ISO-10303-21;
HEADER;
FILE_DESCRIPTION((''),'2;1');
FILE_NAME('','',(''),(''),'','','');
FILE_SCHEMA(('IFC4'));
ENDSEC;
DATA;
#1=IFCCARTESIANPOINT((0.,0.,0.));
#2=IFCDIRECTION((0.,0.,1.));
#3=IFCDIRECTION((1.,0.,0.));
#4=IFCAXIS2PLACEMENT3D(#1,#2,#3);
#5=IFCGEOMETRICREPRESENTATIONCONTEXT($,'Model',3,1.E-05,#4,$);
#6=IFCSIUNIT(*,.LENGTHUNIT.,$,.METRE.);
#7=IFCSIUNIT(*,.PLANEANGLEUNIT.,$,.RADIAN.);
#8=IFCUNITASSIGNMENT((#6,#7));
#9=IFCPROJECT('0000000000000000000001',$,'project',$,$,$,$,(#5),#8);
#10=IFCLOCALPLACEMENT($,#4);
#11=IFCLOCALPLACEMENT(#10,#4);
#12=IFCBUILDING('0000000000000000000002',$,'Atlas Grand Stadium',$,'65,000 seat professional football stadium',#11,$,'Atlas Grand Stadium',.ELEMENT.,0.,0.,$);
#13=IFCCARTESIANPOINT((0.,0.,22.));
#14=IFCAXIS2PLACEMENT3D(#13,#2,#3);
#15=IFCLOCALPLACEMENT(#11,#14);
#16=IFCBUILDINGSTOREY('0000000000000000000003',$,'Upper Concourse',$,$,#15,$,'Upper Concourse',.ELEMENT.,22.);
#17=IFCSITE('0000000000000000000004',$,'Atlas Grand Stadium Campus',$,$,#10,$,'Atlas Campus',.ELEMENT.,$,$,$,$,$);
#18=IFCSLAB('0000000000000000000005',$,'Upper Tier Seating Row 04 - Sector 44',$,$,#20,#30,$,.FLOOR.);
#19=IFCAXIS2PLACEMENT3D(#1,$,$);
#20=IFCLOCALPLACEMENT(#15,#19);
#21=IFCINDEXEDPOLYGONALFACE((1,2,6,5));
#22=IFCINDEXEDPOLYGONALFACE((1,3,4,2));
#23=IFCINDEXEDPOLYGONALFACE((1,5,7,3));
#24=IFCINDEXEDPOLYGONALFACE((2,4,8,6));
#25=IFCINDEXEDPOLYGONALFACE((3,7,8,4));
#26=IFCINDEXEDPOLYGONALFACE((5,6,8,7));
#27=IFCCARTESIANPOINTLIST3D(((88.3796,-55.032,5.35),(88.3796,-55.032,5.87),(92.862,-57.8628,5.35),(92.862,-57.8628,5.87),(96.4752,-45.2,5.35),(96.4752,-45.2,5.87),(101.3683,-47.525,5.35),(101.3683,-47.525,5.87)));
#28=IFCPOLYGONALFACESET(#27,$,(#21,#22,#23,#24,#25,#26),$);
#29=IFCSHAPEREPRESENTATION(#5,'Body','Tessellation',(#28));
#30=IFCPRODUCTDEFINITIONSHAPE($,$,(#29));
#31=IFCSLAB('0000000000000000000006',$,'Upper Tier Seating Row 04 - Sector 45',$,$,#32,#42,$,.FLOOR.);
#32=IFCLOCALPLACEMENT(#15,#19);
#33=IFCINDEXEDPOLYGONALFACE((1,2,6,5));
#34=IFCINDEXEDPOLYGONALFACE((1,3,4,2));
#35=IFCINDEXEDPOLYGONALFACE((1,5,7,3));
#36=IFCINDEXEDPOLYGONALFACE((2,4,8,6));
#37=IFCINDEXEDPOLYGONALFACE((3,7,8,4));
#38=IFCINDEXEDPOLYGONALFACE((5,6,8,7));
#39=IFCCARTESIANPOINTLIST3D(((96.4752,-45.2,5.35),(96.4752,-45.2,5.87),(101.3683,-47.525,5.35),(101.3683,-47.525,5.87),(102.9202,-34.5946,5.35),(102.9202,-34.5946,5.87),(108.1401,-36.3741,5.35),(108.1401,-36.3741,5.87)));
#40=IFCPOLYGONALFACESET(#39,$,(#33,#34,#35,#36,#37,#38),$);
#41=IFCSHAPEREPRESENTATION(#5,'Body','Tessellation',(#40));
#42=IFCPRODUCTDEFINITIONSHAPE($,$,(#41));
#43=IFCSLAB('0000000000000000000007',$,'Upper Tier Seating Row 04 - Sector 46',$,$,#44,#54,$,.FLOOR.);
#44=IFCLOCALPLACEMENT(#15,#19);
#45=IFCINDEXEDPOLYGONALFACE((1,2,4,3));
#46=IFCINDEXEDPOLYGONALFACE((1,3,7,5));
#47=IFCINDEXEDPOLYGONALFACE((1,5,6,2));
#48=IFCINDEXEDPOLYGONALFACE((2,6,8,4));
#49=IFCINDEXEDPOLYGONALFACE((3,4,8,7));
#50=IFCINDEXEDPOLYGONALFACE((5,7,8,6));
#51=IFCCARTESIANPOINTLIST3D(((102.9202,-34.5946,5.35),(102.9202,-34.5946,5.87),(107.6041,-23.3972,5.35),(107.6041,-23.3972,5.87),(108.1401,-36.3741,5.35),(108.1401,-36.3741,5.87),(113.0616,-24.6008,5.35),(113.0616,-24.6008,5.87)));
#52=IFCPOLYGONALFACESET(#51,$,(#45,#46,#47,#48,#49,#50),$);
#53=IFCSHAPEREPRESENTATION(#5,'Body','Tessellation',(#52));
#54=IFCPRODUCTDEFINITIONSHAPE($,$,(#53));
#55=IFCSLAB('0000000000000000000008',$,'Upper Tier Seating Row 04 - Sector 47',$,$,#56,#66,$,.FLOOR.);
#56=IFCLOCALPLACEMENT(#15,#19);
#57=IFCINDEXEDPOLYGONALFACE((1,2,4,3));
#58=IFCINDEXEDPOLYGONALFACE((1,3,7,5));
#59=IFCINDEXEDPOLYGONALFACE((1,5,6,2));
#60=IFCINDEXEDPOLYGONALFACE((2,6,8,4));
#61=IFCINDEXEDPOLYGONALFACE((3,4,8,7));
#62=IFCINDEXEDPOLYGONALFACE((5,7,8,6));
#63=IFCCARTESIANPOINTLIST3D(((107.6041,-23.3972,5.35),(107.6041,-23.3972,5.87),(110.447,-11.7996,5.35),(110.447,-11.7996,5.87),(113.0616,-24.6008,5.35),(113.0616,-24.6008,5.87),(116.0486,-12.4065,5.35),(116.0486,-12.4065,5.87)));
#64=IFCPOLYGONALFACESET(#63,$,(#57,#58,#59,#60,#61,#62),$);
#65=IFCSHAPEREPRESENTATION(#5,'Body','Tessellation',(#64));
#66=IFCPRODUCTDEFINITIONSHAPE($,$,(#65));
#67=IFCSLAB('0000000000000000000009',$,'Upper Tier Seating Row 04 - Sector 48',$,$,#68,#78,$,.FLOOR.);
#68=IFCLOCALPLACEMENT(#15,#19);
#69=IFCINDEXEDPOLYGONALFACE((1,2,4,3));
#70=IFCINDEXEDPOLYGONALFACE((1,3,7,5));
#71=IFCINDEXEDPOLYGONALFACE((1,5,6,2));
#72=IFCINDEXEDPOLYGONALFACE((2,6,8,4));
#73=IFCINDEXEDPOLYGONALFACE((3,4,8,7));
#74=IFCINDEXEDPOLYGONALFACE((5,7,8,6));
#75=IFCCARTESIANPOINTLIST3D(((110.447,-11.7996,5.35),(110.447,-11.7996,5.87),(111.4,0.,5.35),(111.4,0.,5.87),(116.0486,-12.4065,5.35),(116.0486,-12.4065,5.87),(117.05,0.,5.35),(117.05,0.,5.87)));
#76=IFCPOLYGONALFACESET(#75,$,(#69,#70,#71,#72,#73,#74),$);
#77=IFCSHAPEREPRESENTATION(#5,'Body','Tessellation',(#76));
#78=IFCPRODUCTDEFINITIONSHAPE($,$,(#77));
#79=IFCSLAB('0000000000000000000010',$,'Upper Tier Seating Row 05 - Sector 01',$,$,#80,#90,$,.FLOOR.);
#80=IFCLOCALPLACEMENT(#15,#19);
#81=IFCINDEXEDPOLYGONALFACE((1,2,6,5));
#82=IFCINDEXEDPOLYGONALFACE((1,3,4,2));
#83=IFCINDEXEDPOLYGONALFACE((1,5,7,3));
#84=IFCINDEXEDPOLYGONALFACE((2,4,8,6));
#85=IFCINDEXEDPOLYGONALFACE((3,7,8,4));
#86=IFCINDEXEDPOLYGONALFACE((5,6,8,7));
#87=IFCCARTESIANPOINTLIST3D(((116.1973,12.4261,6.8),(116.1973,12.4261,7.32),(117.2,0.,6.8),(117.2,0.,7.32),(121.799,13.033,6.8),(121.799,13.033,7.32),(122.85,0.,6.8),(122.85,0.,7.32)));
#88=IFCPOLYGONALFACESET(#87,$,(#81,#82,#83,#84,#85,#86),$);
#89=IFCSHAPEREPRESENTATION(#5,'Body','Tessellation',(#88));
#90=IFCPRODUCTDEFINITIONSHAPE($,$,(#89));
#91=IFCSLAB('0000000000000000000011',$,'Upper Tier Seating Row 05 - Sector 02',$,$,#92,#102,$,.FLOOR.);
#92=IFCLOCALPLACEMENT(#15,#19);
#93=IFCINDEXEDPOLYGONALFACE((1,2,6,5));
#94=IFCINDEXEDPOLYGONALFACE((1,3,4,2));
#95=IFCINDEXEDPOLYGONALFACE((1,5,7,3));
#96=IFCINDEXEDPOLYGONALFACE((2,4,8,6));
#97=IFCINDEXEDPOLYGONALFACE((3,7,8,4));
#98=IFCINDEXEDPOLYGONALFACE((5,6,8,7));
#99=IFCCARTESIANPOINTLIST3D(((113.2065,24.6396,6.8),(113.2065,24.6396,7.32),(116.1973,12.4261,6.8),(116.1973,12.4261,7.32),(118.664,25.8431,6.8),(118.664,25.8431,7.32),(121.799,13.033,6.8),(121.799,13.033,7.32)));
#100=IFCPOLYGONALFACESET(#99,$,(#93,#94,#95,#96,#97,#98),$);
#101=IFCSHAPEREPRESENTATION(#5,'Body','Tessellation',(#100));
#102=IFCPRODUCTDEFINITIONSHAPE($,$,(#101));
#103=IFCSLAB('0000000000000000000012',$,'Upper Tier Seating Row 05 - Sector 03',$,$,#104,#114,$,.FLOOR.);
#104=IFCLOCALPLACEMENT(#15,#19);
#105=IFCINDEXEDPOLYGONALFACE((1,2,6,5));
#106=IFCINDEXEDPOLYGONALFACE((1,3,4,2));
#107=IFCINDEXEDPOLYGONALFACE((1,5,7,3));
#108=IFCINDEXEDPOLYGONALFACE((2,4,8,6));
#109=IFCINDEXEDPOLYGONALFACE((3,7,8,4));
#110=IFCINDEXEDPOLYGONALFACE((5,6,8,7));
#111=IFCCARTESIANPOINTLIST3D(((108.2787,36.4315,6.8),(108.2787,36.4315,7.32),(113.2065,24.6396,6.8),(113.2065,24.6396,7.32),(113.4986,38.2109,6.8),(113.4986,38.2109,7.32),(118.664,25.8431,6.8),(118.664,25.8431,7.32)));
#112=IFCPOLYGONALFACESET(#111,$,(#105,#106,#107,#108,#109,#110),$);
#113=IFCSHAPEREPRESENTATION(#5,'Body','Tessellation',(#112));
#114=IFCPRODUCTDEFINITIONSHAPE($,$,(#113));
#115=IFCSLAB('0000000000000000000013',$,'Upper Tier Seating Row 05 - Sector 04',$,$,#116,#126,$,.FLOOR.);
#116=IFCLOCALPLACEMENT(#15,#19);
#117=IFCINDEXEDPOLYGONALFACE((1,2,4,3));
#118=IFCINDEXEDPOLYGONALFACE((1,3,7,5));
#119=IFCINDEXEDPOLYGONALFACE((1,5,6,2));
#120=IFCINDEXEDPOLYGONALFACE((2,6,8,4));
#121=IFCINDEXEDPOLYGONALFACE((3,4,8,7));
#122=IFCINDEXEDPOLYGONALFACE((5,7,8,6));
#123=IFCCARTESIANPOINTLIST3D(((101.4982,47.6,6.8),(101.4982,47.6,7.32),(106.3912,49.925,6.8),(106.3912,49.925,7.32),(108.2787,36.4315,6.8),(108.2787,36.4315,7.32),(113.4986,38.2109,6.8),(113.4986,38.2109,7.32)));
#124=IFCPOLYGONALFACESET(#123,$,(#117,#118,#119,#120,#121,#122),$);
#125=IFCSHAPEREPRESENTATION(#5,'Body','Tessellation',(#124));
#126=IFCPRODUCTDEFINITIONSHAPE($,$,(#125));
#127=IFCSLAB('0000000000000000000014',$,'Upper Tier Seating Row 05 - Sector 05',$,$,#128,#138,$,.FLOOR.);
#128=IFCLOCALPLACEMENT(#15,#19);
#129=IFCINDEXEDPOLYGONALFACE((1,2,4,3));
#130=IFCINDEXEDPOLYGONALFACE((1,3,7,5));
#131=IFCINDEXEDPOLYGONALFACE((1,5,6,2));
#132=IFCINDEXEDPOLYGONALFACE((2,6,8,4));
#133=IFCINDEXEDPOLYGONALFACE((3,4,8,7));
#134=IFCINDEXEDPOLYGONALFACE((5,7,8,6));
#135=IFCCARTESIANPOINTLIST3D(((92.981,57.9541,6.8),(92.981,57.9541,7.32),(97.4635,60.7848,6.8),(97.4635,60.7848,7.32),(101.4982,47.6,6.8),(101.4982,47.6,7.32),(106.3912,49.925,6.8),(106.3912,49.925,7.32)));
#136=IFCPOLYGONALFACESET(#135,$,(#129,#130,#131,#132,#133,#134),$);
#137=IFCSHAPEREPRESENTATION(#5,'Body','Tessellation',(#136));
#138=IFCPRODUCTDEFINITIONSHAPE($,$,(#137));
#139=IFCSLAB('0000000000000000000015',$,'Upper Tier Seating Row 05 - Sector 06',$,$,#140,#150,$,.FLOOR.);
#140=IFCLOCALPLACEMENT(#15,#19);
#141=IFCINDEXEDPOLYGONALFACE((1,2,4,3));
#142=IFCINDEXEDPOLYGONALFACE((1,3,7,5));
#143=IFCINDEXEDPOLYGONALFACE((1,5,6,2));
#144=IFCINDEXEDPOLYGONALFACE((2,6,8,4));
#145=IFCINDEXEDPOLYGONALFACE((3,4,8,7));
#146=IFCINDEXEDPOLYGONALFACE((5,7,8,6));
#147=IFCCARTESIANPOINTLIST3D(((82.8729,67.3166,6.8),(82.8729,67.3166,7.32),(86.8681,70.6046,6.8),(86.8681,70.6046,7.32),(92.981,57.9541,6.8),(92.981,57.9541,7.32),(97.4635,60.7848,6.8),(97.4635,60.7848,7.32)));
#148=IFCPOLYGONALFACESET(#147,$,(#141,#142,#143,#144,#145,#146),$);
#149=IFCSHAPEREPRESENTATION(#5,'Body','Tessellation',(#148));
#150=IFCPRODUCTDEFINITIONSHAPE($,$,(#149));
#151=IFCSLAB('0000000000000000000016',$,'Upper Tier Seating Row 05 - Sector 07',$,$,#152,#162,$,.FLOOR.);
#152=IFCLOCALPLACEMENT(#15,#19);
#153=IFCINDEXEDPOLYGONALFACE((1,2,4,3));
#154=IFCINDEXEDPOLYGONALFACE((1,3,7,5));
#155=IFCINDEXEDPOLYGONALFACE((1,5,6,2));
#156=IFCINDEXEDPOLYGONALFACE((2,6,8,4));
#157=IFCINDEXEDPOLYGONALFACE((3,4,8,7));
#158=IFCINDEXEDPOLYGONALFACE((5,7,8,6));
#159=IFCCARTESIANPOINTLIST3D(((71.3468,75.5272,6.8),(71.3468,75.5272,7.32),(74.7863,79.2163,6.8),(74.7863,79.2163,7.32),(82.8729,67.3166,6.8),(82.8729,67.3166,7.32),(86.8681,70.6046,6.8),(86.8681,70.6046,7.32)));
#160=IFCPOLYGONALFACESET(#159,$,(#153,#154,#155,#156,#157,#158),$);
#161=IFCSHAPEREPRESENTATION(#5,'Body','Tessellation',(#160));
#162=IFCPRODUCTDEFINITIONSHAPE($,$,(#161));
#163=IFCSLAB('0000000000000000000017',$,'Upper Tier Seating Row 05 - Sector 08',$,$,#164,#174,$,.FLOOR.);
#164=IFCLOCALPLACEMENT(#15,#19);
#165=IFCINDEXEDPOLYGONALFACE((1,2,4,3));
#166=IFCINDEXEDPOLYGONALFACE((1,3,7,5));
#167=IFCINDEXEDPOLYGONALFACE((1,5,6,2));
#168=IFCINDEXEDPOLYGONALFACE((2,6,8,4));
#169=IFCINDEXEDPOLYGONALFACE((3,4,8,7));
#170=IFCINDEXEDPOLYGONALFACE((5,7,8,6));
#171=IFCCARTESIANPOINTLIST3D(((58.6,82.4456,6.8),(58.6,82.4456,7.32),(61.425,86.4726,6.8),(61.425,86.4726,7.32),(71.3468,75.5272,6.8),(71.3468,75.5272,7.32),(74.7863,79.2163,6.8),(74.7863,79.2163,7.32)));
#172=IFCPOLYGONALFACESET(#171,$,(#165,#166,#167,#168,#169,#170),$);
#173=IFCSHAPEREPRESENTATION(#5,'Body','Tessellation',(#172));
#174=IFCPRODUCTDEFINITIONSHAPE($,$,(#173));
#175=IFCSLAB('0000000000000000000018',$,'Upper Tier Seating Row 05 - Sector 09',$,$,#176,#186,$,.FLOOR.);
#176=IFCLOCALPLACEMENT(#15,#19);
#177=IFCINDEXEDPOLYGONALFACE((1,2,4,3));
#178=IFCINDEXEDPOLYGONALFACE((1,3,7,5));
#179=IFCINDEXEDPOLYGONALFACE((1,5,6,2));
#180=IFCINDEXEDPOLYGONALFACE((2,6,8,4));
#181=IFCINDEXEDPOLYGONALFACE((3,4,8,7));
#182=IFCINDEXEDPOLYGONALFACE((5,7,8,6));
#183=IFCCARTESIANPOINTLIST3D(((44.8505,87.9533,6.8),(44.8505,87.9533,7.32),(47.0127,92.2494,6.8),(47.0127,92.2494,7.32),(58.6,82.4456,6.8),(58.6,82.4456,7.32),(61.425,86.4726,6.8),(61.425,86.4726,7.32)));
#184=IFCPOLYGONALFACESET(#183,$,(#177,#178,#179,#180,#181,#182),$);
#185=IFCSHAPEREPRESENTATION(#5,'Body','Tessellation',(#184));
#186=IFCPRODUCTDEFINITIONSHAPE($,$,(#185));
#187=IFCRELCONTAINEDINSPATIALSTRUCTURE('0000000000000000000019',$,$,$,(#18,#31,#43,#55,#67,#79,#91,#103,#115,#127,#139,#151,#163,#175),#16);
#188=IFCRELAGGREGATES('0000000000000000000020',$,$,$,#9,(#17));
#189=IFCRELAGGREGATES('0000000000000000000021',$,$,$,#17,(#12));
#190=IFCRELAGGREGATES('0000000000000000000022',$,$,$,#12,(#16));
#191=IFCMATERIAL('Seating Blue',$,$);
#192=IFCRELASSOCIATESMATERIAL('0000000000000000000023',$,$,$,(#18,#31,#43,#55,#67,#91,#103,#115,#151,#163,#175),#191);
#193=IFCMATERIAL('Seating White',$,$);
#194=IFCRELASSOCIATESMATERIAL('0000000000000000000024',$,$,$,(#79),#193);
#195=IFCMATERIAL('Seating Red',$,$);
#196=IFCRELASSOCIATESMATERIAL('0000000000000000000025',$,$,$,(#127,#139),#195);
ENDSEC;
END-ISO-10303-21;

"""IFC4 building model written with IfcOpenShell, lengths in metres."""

from ifc_helpers import new_model, si_unit, frame, origin_with_axes, place, context, project, spatial, polyline, outline, extrude, material, element, save


model = new_model("IFC4")

# Units and contexts
model_context = context("Model", 3, precision=1e-05, world=origin_with_axes())
ifc_project = project(units=[si_unit("LENGTHUNIT", "METRE"), si_unit("PLANEANGLEUNIT", "RADIAN")], contexts=[model_context])

# Site, building, storey
site_placement = place(None, origin_with_axes())
site = spatial("IfcSite", under=ifc_project, at=site_placement, Name="Atlas Grand Stadium Campus", LongName="Atlas Campus", CompositionType="ELEMENT")
building_placement = place(site_placement, origin_with_axes())
building = spatial("IfcBuilding", under=site, at=building_placement, Name="Atlas Grand Stadium", ObjectType="65,000 seat professional football stadium", LongName="Atlas Grand Stadium", CompositionType="ELEMENT", ElevationOfRefHeight=0.0, ElevationOfTerrain=0.0)
storey_placement = place(building_placement, frame((0.0, 0.0, 22.0), z_axis=(0.0, 0.0, 1.0), x_axis=(1.0, 0.0, 0.0)))
storey = spatial("IfcBuildingStorey", under=building, at=storey_placement, Name="Upper Concourse", LongName="Upper Concourse", CompositionType="ELEMENT", Elevation=22.0)

# Slabs
ifc_material_1 = material(Name="Seating Blue")
slab_1_placement = place(storey_placement, frame((0.0, 0.0, 5.35), z_axis=(0.0, 0.0, 1.0), x_axis=(1.0, 0.0, 0.0)))
element("IfcSlab", 1, at=slab_1_placement, inside=storey, material=ifc_material_1, Name="Upper Tier Seating Row 04 - Sector 44", PredefinedType="FLOOR", context=model_context, shape_type="SweptSolid", body=[
    extrude(outline(polyline([(92.862, -57.8628), (101.3683, -47.525), (96.4752, -45.2), (88.3796, -55.032), (92.862, -57.8628)])), origin_with_axes(), (0.0, 0.0, 1.0), 0.52),
])
slab_2_placement = place(storey_placement, frame((0.0, 0.0, 5.35), z_axis=(0.0, 0.0, 1.0), x_axis=(1.0, 0.0, 0.0)))
element("IfcSlab", 2, at=slab_2_placement, inside=storey, material=ifc_material_1, Name="Upper Tier Seating Row 04 - Sector 45", PredefinedType="FLOOR", context=model_context, shape_type="SweptSolid", body=[
    extrude(outline(polyline([(101.3683, -47.525), (108.1401, -36.3741), (102.9202, -34.5946), (96.4752, -45.2), (101.3683, -47.525)])), origin_with_axes(), (0.0, 0.0, 1.0), 0.52),
])
slab_3_placement = place(storey_placement, frame((0.0, 0.0, 5.35), z_axis=(0.0, 0.0, 1.0), x_axis=(1.0, 0.0, 0.0)))
element("IfcSlab", 3, at=slab_3_placement, inside=storey, material=ifc_material_1, Name="Upper Tier Seating Row 04 - Sector 46", PredefinedType="FLOOR", context=model_context, shape_type="SweptSolid", body=[
    extrude(outline(polyline([(108.1401, -36.3741), (113.0616, -24.6008), (107.6041, -23.3972), (102.9202, -34.5946), (108.1401, -36.3741)])), origin_with_axes(), (0.0, 0.0, 1.0), 0.52),
])
slab_4_placement = place(storey_placement, frame((0.0, 0.0, 5.35), z_axis=(0.0, 0.0, 1.0), x_axis=(1.0, 0.0, 0.0)))
element("IfcSlab", 4, at=slab_4_placement, inside=storey, material=ifc_material_1, Name="Upper Tier Seating Row 04 - Sector 47", PredefinedType="FLOOR", context=model_context, shape_type="SweptSolid", body=[
    extrude(outline(polyline([(113.0616, -24.6008), (116.0486, -12.4065), (110.447, -11.7996), (107.6041, -23.3972), (113.0616, -24.6008)])), origin_with_axes(), (0.0, 0.0, 1.0), 0.52),
])
slab_5_placement = place(storey_placement, frame((0.0, 0.0, 5.35), z_axis=(0.0, 0.0, 1.0), x_axis=(1.0, 0.0, 0.0)))
element("IfcSlab", 5, at=slab_5_placement, inside=storey, material=ifc_material_1, Name="Upper Tier Seating Row 04 - Sector 48", PredefinedType="FLOOR", context=model_context, shape_type="SweptSolid", body=[
    extrude(outline(polyline([(116.0486, -12.4065), (117.05, 0.0), (111.4, 0.0), (110.447, -11.7996), (116.0486, -12.4065)])), origin_with_axes(), (0.0, 0.0, 1.0), 0.52),
])
ifc_material_2 = material(Name="Seating White")
slab_6_placement = place(storey_placement, frame((0.0, 0.0, 6.8), z_axis=(0.0, 0.0, 1.0), x_axis=(1.0, 0.0, 0.0)))
element("IfcSlab", 6, at=slab_6_placement, inside=storey, material=ifc_material_2, Name="Upper Tier Seating Row 05 - Sector 01", PredefinedType="FLOOR", context=model_context, shape_type="SweptSolid", body=[
    extrude(outline(polyline([(122.85, 0.0), (121.799, 13.033), (116.1973, 12.4261), (117.2, 0.0), (122.85, 0.0)])), origin_with_axes(), (0.0, 0.0, 1.0), 0.52),
])
slab_7_placement = place(storey_placement, frame((0.0, 0.0, 6.8), z_axis=(0.0, 0.0, 1.0), x_axis=(1.0, 0.0, 0.0)))
element("IfcSlab", 7, at=slab_7_placement, inside=storey, material=ifc_material_1, Name="Upper Tier Seating Row 05 - Sector 02", PredefinedType="FLOOR", context=model_context, shape_type="SweptSolid", body=[
    extrude(outline(polyline([(121.799, 13.033), (118.664, 25.8431), (113.2065, 24.6396), (116.1973, 12.4261), (121.799, 13.033)])), origin_with_axes(), (0.0, 0.0, 1.0), 0.52),
])
slab_8_placement = place(storey_placement, frame((0.0, 0.0, 6.8), z_axis=(0.0, 0.0, 1.0), x_axis=(1.0, 0.0, 0.0)))
element("IfcSlab", 8, at=slab_8_placement, inside=storey, material=ifc_material_1, Name="Upper Tier Seating Row 05 - Sector 03", PredefinedType="FLOOR", context=model_context, shape_type="SweptSolid", body=[
    extrude(outline(polyline([(118.664, 25.8431), (113.4986, 38.2109), (108.2787, 36.4315), (113.2065, 24.6396), (118.664, 25.8431)])), origin_with_axes(), (0.0, 0.0, 1.0), 0.52),
])
slab_9_placement = place(storey_placement, frame((0.0, 0.0, 6.8), z_axis=(0.0, 0.0, 1.0), x_axis=(1.0, 0.0, 0.0)))
element("IfcSlab", 9, at=slab_9_placement, inside=storey, material=ifc_material_1, Name="Upper Tier Seating Row 05 - Sector 04", PredefinedType="FLOOR", context=model_context, shape_type="SweptSolid", body=[
    extrude(outline(polyline([(113.4986, 38.2109), (106.3912, 49.925), (101.4982, 47.6), (108.2787, 36.4315), (113.4986, 38.2109)])), origin_with_axes(), (0.0, 0.0, 1.0), 0.52),
])
ifc_material_3 = material(Name="Seating Red")
slab_10_placement = place(storey_placement, frame((0.0, 0.0, 6.8), z_axis=(0.0, 0.0, 1.0), x_axis=(1.0, 0.0, 0.0)))
element("IfcSlab", 10, at=slab_10_placement, inside=storey, material=ifc_material_3, Name="Upper Tier Seating Row 05 - Sector 05", PredefinedType="FLOOR", context=model_context, shape_type="SweptSolid", body=[
    extrude(outline(polyline([(106.3912, 49.925), (97.4635, 60.7848), (92.981, 57.9541), (101.4982, 47.6), (106.3912, 49.925)])), origin_with_axes(), (0.0, 0.0, 1.0), 0.52),
])
slab_11_placement = place(storey_placement, frame((0.0, 0.0, 6.8), z_axis=(0.0, 0.0, 1.0), x_axis=(1.0, 0.0, 0.0)))
element("IfcSlab", 11, at=slab_11_placement, inside=storey, material=ifc_material_3, Name="Upper Tier Seating Row 05 - Sector 06", PredefinedType="FLOOR", context=model_context, shape_type="SweptSolid", body=[
    extrude(outline(polyline([(97.4635, 60.7848), (86.8681, 70.6046), (82.8729, 67.3166), (92.981, 57.9541), (97.4635, 60.7848)])), origin_with_axes(), (0.0, 0.0, 1.0), 0.52),
])
slab_12_placement = place(storey_placement, frame((0.0, 0.0, 6.8), z_axis=(0.0, 0.0, 1.0), x_axis=(1.0, 0.0, 0.0)))
element("IfcSlab", 12, at=slab_12_placement, inside=storey, material=ifc_material_1, Name="Upper Tier Seating Row 05 - Sector 07", PredefinedType="FLOOR", context=model_context, shape_type="SweptSolid", body=[
    extrude(outline(polyline([(86.8681, 70.6046), (74.7863, 79.2163), (71.3468, 75.5272), (82.8729, 67.3166), (86.8681, 70.6046)])), origin_with_axes(), (0.0, 0.0, 1.0), 0.52),
])
slab_13_placement = place(storey_placement, frame((0.0, 0.0, 6.8), z_axis=(0.0, 0.0, 1.0), x_axis=(1.0, 0.0, 0.0)))
element("IfcSlab", 13, at=slab_13_placement, inside=storey, material=ifc_material_1, Name="Upper Tier Seating Row 05 - Sector 08", PredefinedType="FLOOR", context=model_context, shape_type="SweptSolid", body=[
    extrude(outline(polyline([(74.7863, 79.2163), (61.425, 86.4726), (58.6, 82.4456), (71.3468, 75.5272), (74.7863, 79.2163)])), origin_with_axes(), (0.0, 0.0, 1.0), 0.52),
])
slab_14_placement = place(storey_placement, frame((0.0, 0.0, 6.8), z_axis=(0.0, 0.0, 1.0), x_axis=(1.0, 0.0, 0.0)))
element("IfcSlab", 14, at=slab_14_placement, inside=storey, material=ifc_material_1, Name="Upper Tier Seating Row 05 - Sector 09", PredefinedType="FLOOR", context=model_context, shape_type="SweptSolid", body=[
    extrude(outline(polyline([(61.425, 86.4726), (47.0127, 92.2494), (44.8505, 87.9533), (58.6, 82.4456), (61.425, 86.4726)])), origin_with_axes(), (0.0, 0.0, 1.0), 0.52),
])

save(model, "model.ifc")
